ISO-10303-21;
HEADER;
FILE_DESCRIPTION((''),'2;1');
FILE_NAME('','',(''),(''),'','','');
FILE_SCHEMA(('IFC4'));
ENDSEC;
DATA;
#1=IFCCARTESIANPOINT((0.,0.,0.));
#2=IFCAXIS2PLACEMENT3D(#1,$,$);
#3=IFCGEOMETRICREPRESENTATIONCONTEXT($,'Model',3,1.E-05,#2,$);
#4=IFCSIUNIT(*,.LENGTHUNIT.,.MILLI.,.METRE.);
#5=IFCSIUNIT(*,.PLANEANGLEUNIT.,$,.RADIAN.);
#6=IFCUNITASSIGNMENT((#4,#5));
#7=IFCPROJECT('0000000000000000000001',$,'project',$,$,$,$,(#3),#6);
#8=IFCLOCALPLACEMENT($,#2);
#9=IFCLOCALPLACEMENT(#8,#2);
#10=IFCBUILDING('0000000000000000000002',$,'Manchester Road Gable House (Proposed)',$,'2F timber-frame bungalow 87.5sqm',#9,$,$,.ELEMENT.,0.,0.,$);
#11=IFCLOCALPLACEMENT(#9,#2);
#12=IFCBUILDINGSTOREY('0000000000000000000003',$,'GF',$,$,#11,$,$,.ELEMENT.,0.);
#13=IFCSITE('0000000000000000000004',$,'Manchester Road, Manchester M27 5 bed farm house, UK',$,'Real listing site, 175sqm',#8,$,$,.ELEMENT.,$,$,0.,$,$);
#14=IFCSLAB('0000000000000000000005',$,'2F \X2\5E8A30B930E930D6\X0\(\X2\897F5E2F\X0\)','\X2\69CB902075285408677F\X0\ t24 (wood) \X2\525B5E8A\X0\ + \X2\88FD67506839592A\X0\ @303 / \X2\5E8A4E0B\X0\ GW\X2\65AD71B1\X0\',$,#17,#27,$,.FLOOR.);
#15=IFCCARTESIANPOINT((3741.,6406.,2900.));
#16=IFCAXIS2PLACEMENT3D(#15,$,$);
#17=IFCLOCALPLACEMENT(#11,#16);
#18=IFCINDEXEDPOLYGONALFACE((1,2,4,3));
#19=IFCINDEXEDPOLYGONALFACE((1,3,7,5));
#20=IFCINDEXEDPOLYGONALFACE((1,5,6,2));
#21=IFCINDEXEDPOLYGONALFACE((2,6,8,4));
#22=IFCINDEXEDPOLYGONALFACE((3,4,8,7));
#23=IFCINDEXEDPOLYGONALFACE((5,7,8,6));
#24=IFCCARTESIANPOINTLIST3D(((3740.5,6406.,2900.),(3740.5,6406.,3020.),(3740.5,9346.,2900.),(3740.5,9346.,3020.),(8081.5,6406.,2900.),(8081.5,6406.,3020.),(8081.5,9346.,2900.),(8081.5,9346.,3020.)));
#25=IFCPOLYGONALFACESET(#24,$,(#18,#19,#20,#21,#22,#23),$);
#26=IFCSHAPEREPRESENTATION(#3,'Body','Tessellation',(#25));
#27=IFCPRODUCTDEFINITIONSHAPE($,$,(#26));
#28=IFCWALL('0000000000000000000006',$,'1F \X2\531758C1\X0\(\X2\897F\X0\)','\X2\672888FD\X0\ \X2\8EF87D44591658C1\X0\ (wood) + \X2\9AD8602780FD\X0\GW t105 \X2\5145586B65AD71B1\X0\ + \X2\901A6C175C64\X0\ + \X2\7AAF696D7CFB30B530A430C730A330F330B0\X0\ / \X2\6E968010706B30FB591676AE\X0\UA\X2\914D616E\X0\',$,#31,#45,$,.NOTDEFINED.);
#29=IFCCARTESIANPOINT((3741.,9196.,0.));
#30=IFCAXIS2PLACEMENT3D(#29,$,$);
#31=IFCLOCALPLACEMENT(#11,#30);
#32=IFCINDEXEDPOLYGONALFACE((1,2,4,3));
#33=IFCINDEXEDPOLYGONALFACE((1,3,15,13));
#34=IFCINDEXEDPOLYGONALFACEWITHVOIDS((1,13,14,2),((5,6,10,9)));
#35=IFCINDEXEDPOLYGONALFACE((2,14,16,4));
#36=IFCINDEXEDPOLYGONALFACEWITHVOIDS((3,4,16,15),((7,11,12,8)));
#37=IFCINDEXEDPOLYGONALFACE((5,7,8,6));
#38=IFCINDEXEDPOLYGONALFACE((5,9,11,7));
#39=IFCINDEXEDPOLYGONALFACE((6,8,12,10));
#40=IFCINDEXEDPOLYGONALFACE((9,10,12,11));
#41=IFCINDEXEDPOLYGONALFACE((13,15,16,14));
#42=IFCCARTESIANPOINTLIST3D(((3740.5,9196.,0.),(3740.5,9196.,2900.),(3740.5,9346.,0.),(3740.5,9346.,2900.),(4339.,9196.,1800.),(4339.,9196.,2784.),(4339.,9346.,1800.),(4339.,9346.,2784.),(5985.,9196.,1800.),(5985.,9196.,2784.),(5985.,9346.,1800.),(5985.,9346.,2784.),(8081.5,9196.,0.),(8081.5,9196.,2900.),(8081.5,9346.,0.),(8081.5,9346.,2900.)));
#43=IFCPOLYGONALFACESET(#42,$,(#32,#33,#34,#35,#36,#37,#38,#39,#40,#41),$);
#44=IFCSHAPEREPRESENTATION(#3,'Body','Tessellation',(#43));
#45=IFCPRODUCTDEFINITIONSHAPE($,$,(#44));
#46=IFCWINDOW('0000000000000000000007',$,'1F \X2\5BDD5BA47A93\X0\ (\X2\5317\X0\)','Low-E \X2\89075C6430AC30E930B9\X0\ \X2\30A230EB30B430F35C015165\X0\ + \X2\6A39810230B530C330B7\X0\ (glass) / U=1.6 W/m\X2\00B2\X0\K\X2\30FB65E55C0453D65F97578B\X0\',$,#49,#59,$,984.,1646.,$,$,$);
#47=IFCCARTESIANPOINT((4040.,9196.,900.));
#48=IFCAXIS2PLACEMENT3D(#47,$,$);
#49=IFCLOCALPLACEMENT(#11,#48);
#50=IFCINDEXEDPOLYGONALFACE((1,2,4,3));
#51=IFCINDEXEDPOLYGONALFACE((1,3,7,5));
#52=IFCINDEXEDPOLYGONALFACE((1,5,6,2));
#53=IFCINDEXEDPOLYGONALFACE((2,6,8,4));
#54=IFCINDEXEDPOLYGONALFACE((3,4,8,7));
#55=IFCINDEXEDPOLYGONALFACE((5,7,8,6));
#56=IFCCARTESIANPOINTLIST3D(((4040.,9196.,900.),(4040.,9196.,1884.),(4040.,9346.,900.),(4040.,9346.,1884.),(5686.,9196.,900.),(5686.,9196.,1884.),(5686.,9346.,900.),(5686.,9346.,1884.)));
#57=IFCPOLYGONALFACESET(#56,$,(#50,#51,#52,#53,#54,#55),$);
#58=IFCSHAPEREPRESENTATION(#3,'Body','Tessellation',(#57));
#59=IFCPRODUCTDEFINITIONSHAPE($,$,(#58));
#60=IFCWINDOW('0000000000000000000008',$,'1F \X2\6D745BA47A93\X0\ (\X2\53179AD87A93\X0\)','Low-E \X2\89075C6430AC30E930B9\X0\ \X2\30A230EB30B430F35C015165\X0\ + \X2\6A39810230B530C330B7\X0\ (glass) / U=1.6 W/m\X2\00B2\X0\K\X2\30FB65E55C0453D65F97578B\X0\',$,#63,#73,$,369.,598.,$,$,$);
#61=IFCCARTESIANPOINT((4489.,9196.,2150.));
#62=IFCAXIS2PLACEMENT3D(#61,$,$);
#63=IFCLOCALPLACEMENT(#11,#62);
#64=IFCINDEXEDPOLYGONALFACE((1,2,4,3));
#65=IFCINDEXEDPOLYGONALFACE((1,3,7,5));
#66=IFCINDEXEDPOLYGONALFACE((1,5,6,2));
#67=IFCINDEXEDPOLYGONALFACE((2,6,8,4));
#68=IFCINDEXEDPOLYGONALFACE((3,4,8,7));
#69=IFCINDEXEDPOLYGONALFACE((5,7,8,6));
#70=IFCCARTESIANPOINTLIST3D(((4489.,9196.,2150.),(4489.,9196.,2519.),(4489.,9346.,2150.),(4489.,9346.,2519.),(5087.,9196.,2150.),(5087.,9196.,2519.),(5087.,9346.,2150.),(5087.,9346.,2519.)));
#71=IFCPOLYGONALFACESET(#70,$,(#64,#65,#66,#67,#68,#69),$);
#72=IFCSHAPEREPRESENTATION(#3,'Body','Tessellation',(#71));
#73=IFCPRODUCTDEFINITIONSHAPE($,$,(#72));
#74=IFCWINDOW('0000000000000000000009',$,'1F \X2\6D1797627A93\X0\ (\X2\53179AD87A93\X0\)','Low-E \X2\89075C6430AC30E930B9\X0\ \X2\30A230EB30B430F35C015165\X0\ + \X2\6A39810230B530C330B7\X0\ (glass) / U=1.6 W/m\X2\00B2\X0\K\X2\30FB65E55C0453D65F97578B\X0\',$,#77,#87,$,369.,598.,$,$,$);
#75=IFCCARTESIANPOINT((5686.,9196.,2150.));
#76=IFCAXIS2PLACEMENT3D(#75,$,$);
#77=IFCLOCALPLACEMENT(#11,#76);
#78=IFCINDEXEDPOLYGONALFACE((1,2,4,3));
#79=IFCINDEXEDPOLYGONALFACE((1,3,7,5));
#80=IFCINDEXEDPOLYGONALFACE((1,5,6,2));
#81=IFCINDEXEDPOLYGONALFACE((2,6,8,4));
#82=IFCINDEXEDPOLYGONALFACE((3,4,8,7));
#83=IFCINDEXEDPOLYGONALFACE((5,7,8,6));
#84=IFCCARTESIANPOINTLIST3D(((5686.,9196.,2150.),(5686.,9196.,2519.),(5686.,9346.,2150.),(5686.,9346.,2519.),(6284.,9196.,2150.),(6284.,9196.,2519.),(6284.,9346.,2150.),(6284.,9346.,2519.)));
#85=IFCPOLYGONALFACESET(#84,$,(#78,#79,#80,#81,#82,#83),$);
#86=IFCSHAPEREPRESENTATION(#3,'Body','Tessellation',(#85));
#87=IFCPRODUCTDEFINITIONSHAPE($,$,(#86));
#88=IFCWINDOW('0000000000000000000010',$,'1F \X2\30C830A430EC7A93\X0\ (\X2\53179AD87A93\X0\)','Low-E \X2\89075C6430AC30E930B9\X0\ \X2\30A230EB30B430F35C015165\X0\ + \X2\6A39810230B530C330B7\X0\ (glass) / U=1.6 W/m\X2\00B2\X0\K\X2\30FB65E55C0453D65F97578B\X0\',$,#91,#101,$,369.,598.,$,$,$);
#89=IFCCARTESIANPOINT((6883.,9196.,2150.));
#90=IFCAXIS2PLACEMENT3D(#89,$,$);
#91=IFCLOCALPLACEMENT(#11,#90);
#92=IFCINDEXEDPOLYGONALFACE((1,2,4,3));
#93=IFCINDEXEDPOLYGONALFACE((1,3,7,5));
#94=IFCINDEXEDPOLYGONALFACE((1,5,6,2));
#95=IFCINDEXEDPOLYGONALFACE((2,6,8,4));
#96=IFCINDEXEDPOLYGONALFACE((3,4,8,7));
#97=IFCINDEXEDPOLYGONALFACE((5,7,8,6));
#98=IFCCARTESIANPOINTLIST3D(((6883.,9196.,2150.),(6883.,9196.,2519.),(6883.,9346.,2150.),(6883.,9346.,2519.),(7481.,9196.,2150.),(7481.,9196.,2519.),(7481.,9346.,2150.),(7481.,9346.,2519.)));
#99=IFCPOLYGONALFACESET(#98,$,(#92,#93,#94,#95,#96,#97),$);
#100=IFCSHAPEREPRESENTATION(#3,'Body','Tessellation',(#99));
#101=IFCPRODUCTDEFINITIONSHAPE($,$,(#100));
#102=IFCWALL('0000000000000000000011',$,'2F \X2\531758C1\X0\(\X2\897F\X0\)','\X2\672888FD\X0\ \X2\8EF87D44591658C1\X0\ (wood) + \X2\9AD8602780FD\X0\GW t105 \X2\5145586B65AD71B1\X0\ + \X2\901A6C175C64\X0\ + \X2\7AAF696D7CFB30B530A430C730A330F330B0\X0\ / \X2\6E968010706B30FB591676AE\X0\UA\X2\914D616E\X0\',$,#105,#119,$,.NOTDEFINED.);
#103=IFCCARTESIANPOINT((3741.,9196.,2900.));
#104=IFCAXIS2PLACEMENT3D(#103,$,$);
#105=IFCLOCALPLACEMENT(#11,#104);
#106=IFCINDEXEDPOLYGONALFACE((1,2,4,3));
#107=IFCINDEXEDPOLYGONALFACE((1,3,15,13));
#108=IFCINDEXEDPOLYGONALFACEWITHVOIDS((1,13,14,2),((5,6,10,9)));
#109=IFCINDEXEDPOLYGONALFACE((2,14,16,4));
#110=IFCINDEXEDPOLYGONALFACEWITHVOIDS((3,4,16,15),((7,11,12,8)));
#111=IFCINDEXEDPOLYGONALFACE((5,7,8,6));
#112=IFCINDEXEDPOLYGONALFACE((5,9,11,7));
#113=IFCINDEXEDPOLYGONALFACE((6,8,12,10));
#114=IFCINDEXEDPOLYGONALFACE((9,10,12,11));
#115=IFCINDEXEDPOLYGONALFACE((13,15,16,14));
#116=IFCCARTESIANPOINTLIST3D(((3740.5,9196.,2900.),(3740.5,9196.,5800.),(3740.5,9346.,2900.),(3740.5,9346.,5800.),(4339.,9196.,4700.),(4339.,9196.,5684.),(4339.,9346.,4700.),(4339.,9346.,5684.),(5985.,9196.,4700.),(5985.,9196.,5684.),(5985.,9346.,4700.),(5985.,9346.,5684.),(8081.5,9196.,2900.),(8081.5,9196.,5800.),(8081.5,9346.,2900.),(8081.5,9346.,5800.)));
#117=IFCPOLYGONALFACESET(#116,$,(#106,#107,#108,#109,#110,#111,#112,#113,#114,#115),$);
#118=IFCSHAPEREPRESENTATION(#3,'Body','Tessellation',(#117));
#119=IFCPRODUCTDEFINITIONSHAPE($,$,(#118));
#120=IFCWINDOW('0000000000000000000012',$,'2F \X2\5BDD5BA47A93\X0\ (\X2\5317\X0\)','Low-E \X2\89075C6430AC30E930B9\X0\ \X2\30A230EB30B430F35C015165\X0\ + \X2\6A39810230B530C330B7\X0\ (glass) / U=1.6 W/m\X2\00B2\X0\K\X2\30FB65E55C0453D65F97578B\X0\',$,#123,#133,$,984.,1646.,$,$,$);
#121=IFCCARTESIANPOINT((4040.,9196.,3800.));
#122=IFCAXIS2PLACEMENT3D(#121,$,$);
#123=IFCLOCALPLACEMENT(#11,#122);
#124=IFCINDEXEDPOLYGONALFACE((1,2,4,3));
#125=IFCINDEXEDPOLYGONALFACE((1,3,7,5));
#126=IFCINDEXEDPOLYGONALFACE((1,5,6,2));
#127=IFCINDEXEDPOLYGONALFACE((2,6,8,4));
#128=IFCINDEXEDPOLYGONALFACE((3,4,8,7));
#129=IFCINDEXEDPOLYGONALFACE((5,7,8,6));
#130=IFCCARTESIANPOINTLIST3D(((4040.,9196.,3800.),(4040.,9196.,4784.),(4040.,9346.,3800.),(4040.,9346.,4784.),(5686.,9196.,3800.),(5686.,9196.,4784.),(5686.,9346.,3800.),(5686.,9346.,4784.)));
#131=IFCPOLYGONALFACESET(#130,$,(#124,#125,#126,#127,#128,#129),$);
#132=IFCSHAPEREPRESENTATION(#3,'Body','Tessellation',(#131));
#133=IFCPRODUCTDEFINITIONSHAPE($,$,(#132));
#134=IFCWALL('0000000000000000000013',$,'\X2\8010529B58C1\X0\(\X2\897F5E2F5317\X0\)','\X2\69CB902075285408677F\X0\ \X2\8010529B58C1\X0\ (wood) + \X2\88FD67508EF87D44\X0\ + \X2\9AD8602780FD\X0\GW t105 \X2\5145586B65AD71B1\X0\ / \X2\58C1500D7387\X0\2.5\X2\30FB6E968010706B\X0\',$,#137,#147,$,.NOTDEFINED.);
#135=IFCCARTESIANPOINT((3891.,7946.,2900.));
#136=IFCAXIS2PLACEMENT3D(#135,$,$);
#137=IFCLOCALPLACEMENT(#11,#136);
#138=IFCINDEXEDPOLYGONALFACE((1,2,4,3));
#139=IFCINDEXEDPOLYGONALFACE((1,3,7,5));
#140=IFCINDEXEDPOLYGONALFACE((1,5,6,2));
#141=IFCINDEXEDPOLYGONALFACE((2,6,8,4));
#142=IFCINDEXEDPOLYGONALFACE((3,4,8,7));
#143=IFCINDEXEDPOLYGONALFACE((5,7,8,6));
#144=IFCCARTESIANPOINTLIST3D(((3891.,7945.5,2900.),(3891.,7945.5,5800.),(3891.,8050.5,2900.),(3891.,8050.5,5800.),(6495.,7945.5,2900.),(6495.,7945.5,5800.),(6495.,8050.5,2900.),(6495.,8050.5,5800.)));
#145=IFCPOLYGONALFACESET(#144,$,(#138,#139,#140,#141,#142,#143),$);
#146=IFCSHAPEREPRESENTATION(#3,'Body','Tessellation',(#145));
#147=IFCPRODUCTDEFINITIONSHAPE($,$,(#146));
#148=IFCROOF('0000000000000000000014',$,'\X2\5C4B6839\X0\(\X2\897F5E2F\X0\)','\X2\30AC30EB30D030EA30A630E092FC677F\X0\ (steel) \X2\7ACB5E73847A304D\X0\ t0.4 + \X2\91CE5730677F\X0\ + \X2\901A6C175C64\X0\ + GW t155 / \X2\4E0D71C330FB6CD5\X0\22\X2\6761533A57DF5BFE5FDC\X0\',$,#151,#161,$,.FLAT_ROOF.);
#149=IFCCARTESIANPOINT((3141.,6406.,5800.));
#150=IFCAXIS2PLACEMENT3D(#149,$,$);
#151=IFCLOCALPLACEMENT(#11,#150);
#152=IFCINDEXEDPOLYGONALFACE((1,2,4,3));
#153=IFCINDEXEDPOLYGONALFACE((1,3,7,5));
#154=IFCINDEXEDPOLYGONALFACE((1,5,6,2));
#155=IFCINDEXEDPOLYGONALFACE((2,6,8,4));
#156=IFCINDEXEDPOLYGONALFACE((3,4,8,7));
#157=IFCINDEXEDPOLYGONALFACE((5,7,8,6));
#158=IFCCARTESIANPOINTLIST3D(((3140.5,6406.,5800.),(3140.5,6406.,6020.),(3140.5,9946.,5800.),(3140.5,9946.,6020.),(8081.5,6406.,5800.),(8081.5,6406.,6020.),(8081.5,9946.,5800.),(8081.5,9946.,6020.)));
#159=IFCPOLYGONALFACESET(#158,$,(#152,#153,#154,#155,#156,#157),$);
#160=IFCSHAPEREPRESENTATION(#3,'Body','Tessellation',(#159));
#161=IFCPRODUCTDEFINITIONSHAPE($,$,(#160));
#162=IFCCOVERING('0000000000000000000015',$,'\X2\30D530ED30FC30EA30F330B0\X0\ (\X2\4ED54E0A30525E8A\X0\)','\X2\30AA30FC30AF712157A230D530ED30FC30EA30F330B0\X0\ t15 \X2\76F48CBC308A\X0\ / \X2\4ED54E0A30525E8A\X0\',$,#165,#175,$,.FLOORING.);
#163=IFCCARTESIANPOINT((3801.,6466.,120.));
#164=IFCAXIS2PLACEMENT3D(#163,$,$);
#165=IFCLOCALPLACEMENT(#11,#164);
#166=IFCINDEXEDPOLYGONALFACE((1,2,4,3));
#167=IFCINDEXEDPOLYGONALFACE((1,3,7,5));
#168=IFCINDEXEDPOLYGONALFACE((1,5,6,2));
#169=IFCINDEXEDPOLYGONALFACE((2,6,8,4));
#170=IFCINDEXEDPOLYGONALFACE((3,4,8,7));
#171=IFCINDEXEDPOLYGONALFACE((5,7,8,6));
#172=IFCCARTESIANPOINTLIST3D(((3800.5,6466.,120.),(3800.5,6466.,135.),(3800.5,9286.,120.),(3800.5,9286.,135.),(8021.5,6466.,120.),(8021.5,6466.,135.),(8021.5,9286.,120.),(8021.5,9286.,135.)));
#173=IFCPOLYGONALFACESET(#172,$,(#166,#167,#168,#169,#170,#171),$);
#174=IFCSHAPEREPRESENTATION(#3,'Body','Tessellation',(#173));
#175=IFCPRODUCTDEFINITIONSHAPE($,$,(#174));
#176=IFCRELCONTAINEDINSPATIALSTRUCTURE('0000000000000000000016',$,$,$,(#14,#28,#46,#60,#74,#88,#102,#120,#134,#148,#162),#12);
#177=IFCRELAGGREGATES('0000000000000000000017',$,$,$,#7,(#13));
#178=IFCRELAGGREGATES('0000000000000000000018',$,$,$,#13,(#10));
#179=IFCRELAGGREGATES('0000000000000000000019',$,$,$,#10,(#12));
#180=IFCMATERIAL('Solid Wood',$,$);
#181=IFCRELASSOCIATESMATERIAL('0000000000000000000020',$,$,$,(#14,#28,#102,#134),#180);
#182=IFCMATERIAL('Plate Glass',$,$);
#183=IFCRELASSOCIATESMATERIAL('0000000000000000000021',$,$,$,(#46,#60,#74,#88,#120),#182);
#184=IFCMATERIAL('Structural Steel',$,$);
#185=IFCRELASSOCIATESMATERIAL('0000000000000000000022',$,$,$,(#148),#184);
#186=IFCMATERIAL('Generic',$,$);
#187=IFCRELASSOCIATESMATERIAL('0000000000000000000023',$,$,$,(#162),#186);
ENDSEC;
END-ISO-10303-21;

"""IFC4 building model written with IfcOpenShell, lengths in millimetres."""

from ifc_helpers import new_model, si_unit, frame, frame_2d, origin, place, context, project, spatial, rectangle, extrude, material, element, fill, save


model = new_model("IFC4")

# Units and contexts
model_context = context("Model", 3, precision=1e-05, world=origin())
ifc_project = project(units=[si_unit("LENGTHUNIT", "METRE", prefix="MILLI"), si_unit("PLANEANGLEUNIT", "RADIAN")], contexts=[model_context])

# Site, building, storey
site_placement = place(None, origin())
site = spatial("IfcSite", under=ifc_project, at=site_placement, Name="Manchester Road, Manchester M27 5 bed farm house, UK", ObjectType="Real listing site, 175sqm", CompositionType="ELEMENT", RefElevation=0.0)
building_placement = place(site_placement, origin())
building = spatial("IfcBuilding", under=site, at=building_placement, Name="Manchester Road Gable House (Proposed)", ObjectType="2F timber-frame bungalow 87.5sqm", CompositionType="ELEMENT", ElevationOfRefHeight=0.0, ElevationOfTerrain=0.0)
storey_placement = place(building_placement, origin())
storey = spatial("IfcBuildingStorey", under=building, at=storey_placement, Name="GF", CompositionType="ELEMENT", Elevation=0.0)

# Slab
ifc_material_1 = material(Name="Solid Wood")
slab_1_placement = place(storey_placement, frame((3741.0, 6406.0, 2900.0)))
element("IfcSlab", 1, at=slab_1_placement, inside=storey, material=ifc_material_1, Name="2F 床スラブ(西帯)", Description="構造用合板 t24 (wood) 剛床 + 製材根太 @303 / 床下 GW断熱", PredefinedType="FLOOR", context=model_context, shape_type="SweptSolid", body=[
    extrude(rectangle(XDim=4341.0, YDim=2940.0, at=frame_2d((2170.0, 1470.0))), frame((3741.0, 6406.0, 2900.0)), (0.0, 0.0, 1.0), 120.0),
])

# Wall, openings, windows
wall_1_placement = place(storey_placement, frame((3741.0, 9196.0, 0.0)))
wall_1 = element("IfcWall", 2, at=wall_1_placement, inside=storey, material=ifc_material_1, Name="1F 北壁(西)", Description="木製 軸組外壁 (wood) + 高性能GW t105 充填断熱 + 通気層 + 窯業系サイディング / 準耐火・外皮UA配慮", PredefinedType="NOTDEFINED", context=model_context, shape_type="SweptSolid", body=[
    extrude(rectangle(XDim=4341.0, YDim=150.0, at=frame_2d((2170.0, 75.0))), frame((3741.0, 9196.0, 0.0)), (0.0, 0.0, 1.0), 2900.0),
])
opening_1_placement = place(storey_placement, frame((4040.0, 9196.0, 900.0)))
opening_1 = element("IfcOpeningElement", 3, at=opening_1_placement, cuts=wall_1, PredefinedType="NOTDEFINED", context=model_context, shape_type="SweptSolid", body=[
    extrude(rectangle(XDim=1646.0, YDim=150.0, at=frame_2d((823.0, 75.0))), frame((4040.0, 9196.0, 900.0)), (0.0, 0.0, 1.0), 984.0),
])
opening_2_placement = place(storey_placement, frame((4489.0, 9196.0, 2150.0)))
opening_2 = element("IfcOpeningElement", 4, at=opening_2_placement, cuts=wall_1, PredefinedType="NOTDEFINED", context=model_context, shape_type="SweptSolid", body=[
    extrude(rectangle(XDim=598.0, YDim=150.0, at=frame_2d((299.0, 75.0))), frame((4489.0, 9196.0, 2150.0)), (0.0, 0.0, 1.0), 369.0),
])
opening_3_placement = place(storey_placement, frame((5686.0, 9196.0, 2150.0)))
opening_3 = element("IfcOpeningElement", 5, at=opening_3_placement, cuts=wall_1, PredefinedType="NOTDEFINED", context=model_context, shape_type="SweptSolid", body=[
    extrude(rectangle(XDim=598.0, YDim=150.0, at=frame_2d((299.0, 75.0))), frame((5686.0, 9196.0, 2150.0)), (0.0, 0.0, 1.0), 369.0),
])
opening_4_placement = place(storey_placement, frame((6883.0, 9196.0, 2150.0)))
opening_4 = element("IfcOpeningElement", 6, at=opening_4_placement, cuts=wall_1, PredefinedType="NOTDEFINED", context=model_context, shape_type="SweptSolid", body=[
    extrude(rectangle(XDim=598.0, YDim=150.0, at=frame_2d((299.0, 75.0))), frame((6883.0, 9196.0, 2150.0)), (0.0, 0.0, 1.0), 369.0),
])
ifc_material_2 = material(Name="Plate Glass")
window_1_placement = place(storey_placement, frame((4040.0, 9196.0, 900.0)))
window_1 = element("IfcWindow", 7, at=window_1_placement, inside=storey, material=ifc_material_2, Name="1F 寝室窓 (北)", Description="Low-E 複層ガラス アルゴン封入 + 樹脂サッシ (glass) / U=1.6 W/m²K・日射取得型", OverallHeight=984.0, OverallWidth=1646.0, context=model_context, shape_type="SweptSolid", body=[
    extrude(rectangle(XDim=1646.0, YDim=150.0, at=frame_2d((823.0, 75.0))), frame((4040.0, 9196.0, 900.0)), (0.0, 0.0, 1.0), 984.0),
])
fill(opening_1, window_1)
window_2_placement = place(storey_placement, frame((4489.0, 9196.0, 2150.0)))
window_2 = element("IfcWindow", 8, at=window_2_placement, inside=storey, material=ifc_material_2, Name="1F 浴室窓 (北高窓)", Description="Low-E 複層ガラス アルゴン封入 + 樹脂サッシ (glass) / U=1.6 W/m²K・日射取得型", OverallHeight=369.0, OverallWidth=598.0, context=model_context, shape_type="SweptSolid", body=[
    extrude(rectangle(XDim=598.0, YDim=150.0, at=frame_2d((299.0, 75.0))), frame((4489.0, 9196.0, 2150.0)), (0.0, 0.0, 1.0), 369.0),
])
fill(opening_2, window_2)
window_3_placement = place(storey_placement, frame((5686.0, 9196.0, 2150.0)))
window_3 = element("IfcWindow", 9, at=window_3_placement, inside=storey, material=ifc_material_2, Name="1F 洗面窓 (北高窓)", Description="Low-E 複層ガラス アルゴン封入 + 樹脂サッシ (glass) / U=1.6 W/m²K・日射取得型", OverallHeight=369.0, OverallWidth=598.0, context=model_context, shape_type="SweptSolid", body=[
    extrude(rectangle(XDim=598.0, YDim=150.0, at=frame_2d((299.0, 75.0))), frame((5686.0, 9196.0, 2150.0)), (0.0, 0.0, 1.0), 369.0),
])
fill(opening_3, window_3)
window_4_placement = place(storey_placement, frame((6883.0, 9196.0, 2150.0)))
window_4 = element("IfcWindow", 10, at=window_4_placement, inside=storey, material=ifc_material_2, Name="1F トイレ窓 (北高窓)", Description="Low-E 複層ガラス アルゴン封入 + 樹脂サッシ (glass) / U=1.6 W/m²K・日射取得型", OverallHeight=369.0, OverallWidth=598.0, context=model_context, shape_type="SweptSolid", body=[
    extrude(rectangle(XDim=598.0, YDim=150.0, at=frame_2d((299.0, 75.0))), frame((6883.0, 9196.0, 2150.0)), (0.0, 0.0, 1.0), 369.0),
])
fill(opening_4, window_4)

# Wall, opening, window
wall_2_placement = place(storey_placement, frame((3741.0, 9196.0, 2900.0)))
wall_2 = element("IfcWall", 11, at=wall_2_placement, inside=storey, material=ifc_material_1, Name="2F 北壁(西)", Description="木製 軸組外壁 (wood) + 高性能GW t105 充填断熱 + 通気層 + 窯業系サイディング / 準耐火・外皮UA配慮", PredefinedType="NOTDEFINED", context=model_context, shape_type="SweptSolid", body=[
    extrude(rectangle(XDim=4341.0, YDim=150.0, at=frame_2d((2170.0, 75.0))), frame((3741.0, 9196.0, 2900.0)), (0.0, 0.0, 1.0), 2900.0),
])
opening_5_placement = place(storey_placement, frame((4040.0, 9196.0, 3800.0)))
opening_5 = element("IfcOpeningElement", 12, at=opening_5_placement, cuts=wall_2, PredefinedType="NOTDEFINED", context=model_context, shape_type="SweptSolid", body=[
    extrude(rectangle(XDim=1646.0, YDim=150.0, at=frame_2d((823.0, 75.0))), frame((4040.0, 9196.0, 3800.0)), (0.0, 0.0, 1.0), 984.0),
])
window_5_placement = place(storey_placement, frame((4040.0, 9196.0, 3800.0)))
window_5 = element("IfcWindow", 13, at=window_5_placement, inside=storey, material=ifc_material_2, Name="2F 寝室窓 (北)", Description="Low-E 複層ガラス アルゴン封入 + 樹脂サッシ (glass) / U=1.6 W/m²K・日射取得型", OverallHeight=984.0, OverallWidth=1646.0, context=model_context, shape_type="SweptSolid", body=[
    extrude(rectangle(XDim=1646.0, YDim=150.0, at=frame_2d((823.0, 75.0))), frame((4040.0, 9196.0, 3800.0)), (0.0, 0.0, 1.0), 984.0),
])
fill(opening_5, window_5)

# Wall
wall_3_placement = place(storey_placement, frame((3891.0, 7946.0, 2900.0)))
element("IfcWall", 14, at=wall_3_placement, inside=storey, material=ifc_material_1, Name="耐力壁(西帯北)", Description="構造用合板 耐力壁 (wood) + 製材軸組 + 高性能GW t105 充填断熱 / 壁倍率2.5・準耐火", PredefinedType="NOTDEFINED", context=model_context, shape_type="SweptSolid", body=[
    extrude(rectangle(XDim=2604.0, YDim=105.0, at=frame_2d((1302.0, 52.0))), frame((3891.0, 7946.0, 2900.0)), (0.0, 0.0, 1.0), 2900.0),
])

# Roof
ifc_material_3 = material(Name="Structural Steel")
for number, where, name in (
    (15, (3141.0, 6406.0, 5800.0), "屋根(西帯)"),
):
    element("IfcRoof", number, at=place(storey_placement, frame(where)), inside=storey, material=ifc_material_3, Name=name, Description="ガルバリウム鋼板 (steel) 立平葺き t0.4 + 野地板 + 通気層 + GW t155 / 不燃・法22条区域対応", PredefinedType="FLAT_ROOF", context=model_context, shape_type="SweptSolid", body=[
        extrude(rectangle(XDim=4941.0, YDim=3540.0, at=frame_2d((2470.0, 1770.0))), frame((3141.0, 6406.0, 5800.0)), (0.0, 0.0, 1.0), 220.0),
    ])

# Covering
ifc_material_4 = material(Name="Generic")
covering_1_placement = place(storey_placement, frame((3801.0, 6466.0, 120.0)))
element("IfcCovering", 16, at=covering_1_placement, inside=storey, material=ifc_material_4, Name="フローリング (仕上げ床)", Description="オーク無垢フローリング t15 直貼り / 仕上げ床", PredefinedType="FLOORING", context=model_context, shape_type="SweptSolid", body=[
    extrude(rectangle(XDim=4221.0, YDim=2820.0, at=frame_2d((2110.0, 1410.0))), frame((3801.0, 6466.0, 120.0)), (0.0, 0.0, 1.0), 15.0),
])

save(model, "model.ifc")
